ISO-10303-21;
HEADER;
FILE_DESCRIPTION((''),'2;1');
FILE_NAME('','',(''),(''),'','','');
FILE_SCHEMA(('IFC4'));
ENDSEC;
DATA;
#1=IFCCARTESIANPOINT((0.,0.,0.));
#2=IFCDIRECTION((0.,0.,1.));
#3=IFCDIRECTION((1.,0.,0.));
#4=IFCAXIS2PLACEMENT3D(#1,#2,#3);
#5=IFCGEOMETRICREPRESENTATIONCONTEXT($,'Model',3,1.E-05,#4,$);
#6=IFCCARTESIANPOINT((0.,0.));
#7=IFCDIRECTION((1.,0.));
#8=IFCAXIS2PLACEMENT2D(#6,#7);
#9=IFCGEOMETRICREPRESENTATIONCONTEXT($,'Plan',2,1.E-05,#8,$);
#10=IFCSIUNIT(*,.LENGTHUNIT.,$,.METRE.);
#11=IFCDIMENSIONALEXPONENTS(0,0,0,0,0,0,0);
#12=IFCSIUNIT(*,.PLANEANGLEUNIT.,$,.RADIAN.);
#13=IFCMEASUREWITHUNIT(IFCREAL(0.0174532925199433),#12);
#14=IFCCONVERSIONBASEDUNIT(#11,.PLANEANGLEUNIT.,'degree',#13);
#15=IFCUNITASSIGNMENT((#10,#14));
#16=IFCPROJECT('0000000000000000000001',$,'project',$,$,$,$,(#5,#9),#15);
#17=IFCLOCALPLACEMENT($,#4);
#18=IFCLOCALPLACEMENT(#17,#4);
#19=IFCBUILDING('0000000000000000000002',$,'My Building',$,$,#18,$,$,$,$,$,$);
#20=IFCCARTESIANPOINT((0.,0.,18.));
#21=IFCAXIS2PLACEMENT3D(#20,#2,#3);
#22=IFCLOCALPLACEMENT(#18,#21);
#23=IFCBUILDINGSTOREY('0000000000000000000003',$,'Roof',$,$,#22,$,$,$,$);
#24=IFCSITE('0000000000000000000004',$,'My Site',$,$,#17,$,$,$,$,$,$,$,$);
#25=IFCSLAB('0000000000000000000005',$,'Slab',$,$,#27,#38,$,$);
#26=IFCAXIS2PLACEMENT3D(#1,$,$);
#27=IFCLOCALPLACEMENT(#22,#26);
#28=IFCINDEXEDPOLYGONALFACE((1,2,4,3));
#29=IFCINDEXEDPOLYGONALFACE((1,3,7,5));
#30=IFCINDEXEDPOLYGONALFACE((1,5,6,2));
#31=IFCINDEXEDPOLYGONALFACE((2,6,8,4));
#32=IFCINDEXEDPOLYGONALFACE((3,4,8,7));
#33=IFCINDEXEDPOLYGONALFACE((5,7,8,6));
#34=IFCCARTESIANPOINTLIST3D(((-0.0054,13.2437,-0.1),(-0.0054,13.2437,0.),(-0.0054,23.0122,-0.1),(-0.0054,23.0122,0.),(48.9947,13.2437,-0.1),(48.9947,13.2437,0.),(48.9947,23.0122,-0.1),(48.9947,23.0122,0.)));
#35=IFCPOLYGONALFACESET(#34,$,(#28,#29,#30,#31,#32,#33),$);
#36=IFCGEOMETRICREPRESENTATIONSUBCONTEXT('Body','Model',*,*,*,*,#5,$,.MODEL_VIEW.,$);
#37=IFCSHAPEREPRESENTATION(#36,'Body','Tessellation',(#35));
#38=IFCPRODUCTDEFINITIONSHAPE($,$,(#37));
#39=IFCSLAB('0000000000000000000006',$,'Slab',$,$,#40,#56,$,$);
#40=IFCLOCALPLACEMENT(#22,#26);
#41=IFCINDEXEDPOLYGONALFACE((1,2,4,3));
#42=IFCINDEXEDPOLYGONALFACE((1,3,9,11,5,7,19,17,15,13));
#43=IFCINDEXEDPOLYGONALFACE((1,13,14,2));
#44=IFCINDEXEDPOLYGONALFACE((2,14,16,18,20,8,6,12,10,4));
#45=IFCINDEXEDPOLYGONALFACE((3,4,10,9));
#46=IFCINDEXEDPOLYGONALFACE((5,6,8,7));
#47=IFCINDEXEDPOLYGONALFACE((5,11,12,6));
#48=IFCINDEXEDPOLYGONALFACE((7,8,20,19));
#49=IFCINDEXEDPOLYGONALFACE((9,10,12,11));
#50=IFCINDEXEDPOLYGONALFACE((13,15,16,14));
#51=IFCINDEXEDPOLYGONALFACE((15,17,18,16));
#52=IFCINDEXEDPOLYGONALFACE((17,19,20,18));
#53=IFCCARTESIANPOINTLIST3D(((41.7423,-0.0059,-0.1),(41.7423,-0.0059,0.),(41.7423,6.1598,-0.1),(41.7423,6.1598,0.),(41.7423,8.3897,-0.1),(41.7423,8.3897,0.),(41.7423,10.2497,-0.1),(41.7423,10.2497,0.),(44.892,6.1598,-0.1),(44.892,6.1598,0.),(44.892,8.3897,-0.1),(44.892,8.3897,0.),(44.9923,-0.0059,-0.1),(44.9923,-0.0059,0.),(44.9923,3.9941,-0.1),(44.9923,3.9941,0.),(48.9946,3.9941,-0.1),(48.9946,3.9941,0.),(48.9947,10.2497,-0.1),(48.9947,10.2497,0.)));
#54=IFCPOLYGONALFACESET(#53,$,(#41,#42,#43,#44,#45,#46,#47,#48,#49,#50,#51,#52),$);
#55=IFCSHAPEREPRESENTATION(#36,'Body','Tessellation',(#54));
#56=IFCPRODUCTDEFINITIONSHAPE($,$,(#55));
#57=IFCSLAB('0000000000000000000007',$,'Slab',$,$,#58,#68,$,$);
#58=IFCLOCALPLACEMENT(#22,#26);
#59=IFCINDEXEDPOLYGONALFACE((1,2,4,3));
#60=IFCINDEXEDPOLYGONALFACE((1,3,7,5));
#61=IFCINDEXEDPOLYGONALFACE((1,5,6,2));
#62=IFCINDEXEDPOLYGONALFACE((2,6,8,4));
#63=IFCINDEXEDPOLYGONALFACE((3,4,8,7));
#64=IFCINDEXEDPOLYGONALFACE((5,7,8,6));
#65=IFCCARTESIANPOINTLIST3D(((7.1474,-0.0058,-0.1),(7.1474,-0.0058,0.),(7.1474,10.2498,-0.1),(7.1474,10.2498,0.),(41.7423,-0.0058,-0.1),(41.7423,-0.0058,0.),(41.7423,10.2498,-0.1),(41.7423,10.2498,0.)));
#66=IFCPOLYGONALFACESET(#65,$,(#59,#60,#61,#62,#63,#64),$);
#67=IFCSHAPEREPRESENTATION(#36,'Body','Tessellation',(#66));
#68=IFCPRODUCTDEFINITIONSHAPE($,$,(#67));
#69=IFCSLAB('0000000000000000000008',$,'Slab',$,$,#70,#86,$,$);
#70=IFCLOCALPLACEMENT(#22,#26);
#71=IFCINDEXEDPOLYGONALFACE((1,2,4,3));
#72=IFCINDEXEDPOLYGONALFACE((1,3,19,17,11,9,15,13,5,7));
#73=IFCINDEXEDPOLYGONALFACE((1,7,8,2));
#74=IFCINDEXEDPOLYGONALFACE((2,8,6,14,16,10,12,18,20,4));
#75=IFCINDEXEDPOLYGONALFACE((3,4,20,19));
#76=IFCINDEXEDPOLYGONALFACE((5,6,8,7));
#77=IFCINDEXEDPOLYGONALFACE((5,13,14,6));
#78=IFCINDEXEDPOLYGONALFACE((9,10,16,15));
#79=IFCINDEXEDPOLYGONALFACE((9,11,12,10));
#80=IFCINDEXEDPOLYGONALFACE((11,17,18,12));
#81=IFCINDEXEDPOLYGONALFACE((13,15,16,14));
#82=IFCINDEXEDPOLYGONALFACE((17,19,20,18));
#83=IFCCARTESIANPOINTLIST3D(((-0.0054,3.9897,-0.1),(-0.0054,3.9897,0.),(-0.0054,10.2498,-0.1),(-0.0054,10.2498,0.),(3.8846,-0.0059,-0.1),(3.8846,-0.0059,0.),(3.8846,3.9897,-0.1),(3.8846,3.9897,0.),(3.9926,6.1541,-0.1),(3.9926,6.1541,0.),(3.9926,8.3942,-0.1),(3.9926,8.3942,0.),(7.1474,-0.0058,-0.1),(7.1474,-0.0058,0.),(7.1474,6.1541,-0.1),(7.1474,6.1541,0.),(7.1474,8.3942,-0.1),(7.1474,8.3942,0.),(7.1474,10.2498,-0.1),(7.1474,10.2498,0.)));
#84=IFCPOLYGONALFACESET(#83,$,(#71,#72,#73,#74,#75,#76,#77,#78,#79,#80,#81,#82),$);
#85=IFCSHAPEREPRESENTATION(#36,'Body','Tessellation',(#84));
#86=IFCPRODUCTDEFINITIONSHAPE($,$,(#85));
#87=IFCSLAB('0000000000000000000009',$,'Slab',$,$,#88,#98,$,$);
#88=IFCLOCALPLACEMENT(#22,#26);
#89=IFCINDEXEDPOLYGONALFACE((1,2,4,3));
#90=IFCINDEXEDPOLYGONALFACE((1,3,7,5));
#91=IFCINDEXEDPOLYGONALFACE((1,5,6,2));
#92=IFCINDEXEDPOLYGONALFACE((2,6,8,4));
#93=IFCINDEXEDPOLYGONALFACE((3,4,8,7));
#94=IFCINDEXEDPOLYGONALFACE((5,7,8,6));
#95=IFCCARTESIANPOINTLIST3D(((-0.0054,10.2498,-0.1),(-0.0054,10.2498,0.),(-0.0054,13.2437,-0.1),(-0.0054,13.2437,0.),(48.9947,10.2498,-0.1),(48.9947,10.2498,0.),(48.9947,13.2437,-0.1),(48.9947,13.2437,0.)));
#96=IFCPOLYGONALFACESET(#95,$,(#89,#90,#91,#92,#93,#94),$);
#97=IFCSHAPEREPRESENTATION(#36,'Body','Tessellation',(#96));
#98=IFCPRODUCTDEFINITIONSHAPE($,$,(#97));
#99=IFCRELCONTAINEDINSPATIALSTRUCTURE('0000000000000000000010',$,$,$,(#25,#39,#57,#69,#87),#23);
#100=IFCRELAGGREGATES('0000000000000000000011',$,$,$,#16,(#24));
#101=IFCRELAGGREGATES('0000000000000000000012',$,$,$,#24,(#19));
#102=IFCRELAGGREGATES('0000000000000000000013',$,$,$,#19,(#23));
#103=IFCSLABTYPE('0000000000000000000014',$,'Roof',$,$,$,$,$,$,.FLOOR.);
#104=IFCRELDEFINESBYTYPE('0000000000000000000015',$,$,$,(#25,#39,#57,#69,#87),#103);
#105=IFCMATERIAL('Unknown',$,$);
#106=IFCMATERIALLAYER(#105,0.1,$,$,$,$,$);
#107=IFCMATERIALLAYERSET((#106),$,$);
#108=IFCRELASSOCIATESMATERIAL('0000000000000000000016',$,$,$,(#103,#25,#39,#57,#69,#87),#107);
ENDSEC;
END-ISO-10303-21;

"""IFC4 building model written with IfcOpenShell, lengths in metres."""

from ifc_helpers import new_model, entity, si_unit, converted_unit, frame, origin_with_axes, origin_2d_with_axis, place, context, subcontext, project, spatial, indexed_curve, outline, extrude, material, layer, layer_set, layer_usage, type_object, element, save


model = new_model("IFC4")

# Units and contexts
model_context = context("Model", 3, precision=1e-05, world=origin_with_axes())
plan_context = context("Plan", 2, precision=1e-05, world=origin_2d_with_axis())
body_context = subcontext(model_context, "Body", "Model", "MODEL_VIEW")
ifc_project = project(units=[si_unit("LENGTHUNIT", "METRE"), converted_unit("PLANEANGLEUNIT", "degree", entity("IfcReal", 0.0174532925199433), si_unit("PLANEANGLEUNIT", "RADIAN"), dimensions=[0, 0, 0, 0, 0, 0, 0])], contexts=[model_context, plan_context])

# Site, building, storey
site_placement = place(None, origin_with_axes())
site = spatial("IfcSite", under=ifc_project, at=site_placement, Name="My Site")
building_placement = place(site_placement, origin_with_axes())
building = spatial("IfcBuilding", under=site, at=building_placement, Name="My Building")
storey_placement = place(building_placement, frame((0.0, 0.0, 18.0), z_axis=(0.0, 0.0, 1.0), x_axis=(1.0, 0.0, 0.0)))
storey = spatial("IfcBuildingStorey", under=building, at=storey_placement, Name="Roof")

# Slabs
ifc_material = material(Name="Unknown")
ifc_layer = layer(ifc_material, 0.1)
ifc_layer_set = layer_set([ifc_layer])
ifc_layer_usage_1 = layer_usage(ifc_layer_set, "AXIS3", "POSITIVE", -0.1)
slab_type = type_object("IfcSlabType", Name="Roof", PredefinedType="FLOOR", material=ifc_layer_set)
slab_1_placement = place(storey_placement, frame((48.9947, 23.0122, 0.0), z_axis=(0.0, 0.0, 1.0), x_axis=(1.0, 0.0, 0.0)))
element("IfcSlab", 1, at=slab_1_placement, inside=storey, type_object=slab_type, material=ifc_layer_usage_1, Name="Slab", context=body_context, shape_type="SweptSolid", body=[
    extrude(outline(indexed_curve([(0.0, 0.0), (-49.0001, 0.0), (-49.0001, -9.7685), (0.0, -9.7685), (0.0, 0.0)])), frame((0.0, 0.0, -0.1), z_axis=(0.0, 0.0, 1.0), x_axis=(1.0, 0.0, 0.0)), (0.0, 0.0, 1.0), 0.1),
])
ifc_layer_usage_2 = layer_usage(ifc_layer_set, "AXIS3", "POSITIVE", -0.1)
slab_2_placement = place(storey_placement, frame((48.9947, 10.2497, 0.0), z_axis=(0.0, 0.0, 1.0), x_axis=(1.0, 0.0, 0.0)))
element("IfcSlab", 2, at=slab_2_placement, inside=storey, type_object=slab_type, material=ifc_layer_usage_2, Name="Slab", context=body_context, shape_type="SweptSolid", body=[
    extrude(outline(indexed_curve([(0.0, 0.0), (-7.2524, 0.0), (-7.2524, -1.86), (-4.1027, -1.86), (-4.1027, -4.0899), (-7.2524, -4.0899), (-7.2524, -10.2556), (-4.0024, -10.2556), (-4.0024, -6.2557), (-0.0001, -6.2557), (0.0, 0.0)])), frame((0.0, 0.0, -0.1), z_axis=(0.0, 0.0, 1.0), x_axis=(1.0, 0.0, 0.0)), (0.0, 0.0, 1.0), 0.1),
])
ifc_layer_usage_3 = layer_usage(ifc_layer_set, "AXIS3", "POSITIVE", -0.1)
slab_3_placement = place(storey_placement, frame((41.7423, -0.0058, 0.0), z_axis=(0.0, 0.0, 1.0), x_axis=(1.0, 0.0, 0.0)))
element("IfcSlab", 3, at=slab_3_placement, inside=storey, type_object=slab_type, material=ifc_layer_usage_3, Name="Slab", context=body_context, shape_type="SweptSolid", body=[
    extrude(outline(indexed_curve([(0.0, 0.0), (0.0, 10.2556), (-34.5949, 10.2556), (-34.5949, 0.0), (0.0, 0.0)])), frame((0.0, 0.0, -0.1), z_axis=(0.0, 0.0, 1.0), x_axis=(1.0, 0.0, 0.0)), (0.0, 0.0, 1.0), 0.1),
])
ifc_layer_usage_4 = layer_usage(ifc_layer_set, "AXIS3", "POSITIVE", -0.1)
slab_4_placement = place(storey_placement, frame((7.1474, -0.0058, 0.0), z_axis=(0.0, 0.0, 1.0), x_axis=(1.0, 0.0, 0.0)))
element("IfcSlab", 4, at=slab_4_placement, inside=storey, type_object=slab_type, material=ifc_layer_usage_4, Name="Slab", context=body_context, shape_type="SweptSolid", body=[
    extrude(outline(indexed_curve([(0.0, 0.0), (0.0, 6.16), (-3.1548, 6.16), (-3.1548, 8.4), (0.0, 8.4), (0.0, 10.2556), (-7.1528, 10.2556), (-7.1528, 3.9956), (-3.2628, 3.9956), (-3.2628, -0.0001), (0.0, 0.0)])), frame((0.0, 0.0, -0.1), z_axis=(0.0, 0.0, 1.0), x_axis=(1.0, 0.0, 0.0)), (0.0, 0.0, 1.0), 0.1),
])
ifc_layer_usage_5 = layer_usage(ifc_layer_set, "AXIS3", "POSITIVE", -0.1)
slab_5_placement = place(storey_placement, frame((-0.0054, 13.2437, 0.0), z_axis=(0.0, 0.0, 1.0), x_axis=(1.0, 0.0, 0.0)))
element("IfcSlab", 5, at=slab_5_placement, inside=storey, type_object=slab_type, material=ifc_layer_usage_5, Name="Slab", context=body_context, shape_type="SweptSolid", body=[
    extrude(outline(indexed_curve([(0.0, 0.0), (49.0001, 0.0), (49.0001, -2.994), (0.0, -2.994), (0.0, 0.0)])), frame((0.0, 0.0, -0.1), z_axis=(0.0, 0.0, 1.0), x_axis=(1.0, 0.0, 0.0)), (0.0, 0.0, 1.0), 0.1),
])

save(model, "model.ifc")
